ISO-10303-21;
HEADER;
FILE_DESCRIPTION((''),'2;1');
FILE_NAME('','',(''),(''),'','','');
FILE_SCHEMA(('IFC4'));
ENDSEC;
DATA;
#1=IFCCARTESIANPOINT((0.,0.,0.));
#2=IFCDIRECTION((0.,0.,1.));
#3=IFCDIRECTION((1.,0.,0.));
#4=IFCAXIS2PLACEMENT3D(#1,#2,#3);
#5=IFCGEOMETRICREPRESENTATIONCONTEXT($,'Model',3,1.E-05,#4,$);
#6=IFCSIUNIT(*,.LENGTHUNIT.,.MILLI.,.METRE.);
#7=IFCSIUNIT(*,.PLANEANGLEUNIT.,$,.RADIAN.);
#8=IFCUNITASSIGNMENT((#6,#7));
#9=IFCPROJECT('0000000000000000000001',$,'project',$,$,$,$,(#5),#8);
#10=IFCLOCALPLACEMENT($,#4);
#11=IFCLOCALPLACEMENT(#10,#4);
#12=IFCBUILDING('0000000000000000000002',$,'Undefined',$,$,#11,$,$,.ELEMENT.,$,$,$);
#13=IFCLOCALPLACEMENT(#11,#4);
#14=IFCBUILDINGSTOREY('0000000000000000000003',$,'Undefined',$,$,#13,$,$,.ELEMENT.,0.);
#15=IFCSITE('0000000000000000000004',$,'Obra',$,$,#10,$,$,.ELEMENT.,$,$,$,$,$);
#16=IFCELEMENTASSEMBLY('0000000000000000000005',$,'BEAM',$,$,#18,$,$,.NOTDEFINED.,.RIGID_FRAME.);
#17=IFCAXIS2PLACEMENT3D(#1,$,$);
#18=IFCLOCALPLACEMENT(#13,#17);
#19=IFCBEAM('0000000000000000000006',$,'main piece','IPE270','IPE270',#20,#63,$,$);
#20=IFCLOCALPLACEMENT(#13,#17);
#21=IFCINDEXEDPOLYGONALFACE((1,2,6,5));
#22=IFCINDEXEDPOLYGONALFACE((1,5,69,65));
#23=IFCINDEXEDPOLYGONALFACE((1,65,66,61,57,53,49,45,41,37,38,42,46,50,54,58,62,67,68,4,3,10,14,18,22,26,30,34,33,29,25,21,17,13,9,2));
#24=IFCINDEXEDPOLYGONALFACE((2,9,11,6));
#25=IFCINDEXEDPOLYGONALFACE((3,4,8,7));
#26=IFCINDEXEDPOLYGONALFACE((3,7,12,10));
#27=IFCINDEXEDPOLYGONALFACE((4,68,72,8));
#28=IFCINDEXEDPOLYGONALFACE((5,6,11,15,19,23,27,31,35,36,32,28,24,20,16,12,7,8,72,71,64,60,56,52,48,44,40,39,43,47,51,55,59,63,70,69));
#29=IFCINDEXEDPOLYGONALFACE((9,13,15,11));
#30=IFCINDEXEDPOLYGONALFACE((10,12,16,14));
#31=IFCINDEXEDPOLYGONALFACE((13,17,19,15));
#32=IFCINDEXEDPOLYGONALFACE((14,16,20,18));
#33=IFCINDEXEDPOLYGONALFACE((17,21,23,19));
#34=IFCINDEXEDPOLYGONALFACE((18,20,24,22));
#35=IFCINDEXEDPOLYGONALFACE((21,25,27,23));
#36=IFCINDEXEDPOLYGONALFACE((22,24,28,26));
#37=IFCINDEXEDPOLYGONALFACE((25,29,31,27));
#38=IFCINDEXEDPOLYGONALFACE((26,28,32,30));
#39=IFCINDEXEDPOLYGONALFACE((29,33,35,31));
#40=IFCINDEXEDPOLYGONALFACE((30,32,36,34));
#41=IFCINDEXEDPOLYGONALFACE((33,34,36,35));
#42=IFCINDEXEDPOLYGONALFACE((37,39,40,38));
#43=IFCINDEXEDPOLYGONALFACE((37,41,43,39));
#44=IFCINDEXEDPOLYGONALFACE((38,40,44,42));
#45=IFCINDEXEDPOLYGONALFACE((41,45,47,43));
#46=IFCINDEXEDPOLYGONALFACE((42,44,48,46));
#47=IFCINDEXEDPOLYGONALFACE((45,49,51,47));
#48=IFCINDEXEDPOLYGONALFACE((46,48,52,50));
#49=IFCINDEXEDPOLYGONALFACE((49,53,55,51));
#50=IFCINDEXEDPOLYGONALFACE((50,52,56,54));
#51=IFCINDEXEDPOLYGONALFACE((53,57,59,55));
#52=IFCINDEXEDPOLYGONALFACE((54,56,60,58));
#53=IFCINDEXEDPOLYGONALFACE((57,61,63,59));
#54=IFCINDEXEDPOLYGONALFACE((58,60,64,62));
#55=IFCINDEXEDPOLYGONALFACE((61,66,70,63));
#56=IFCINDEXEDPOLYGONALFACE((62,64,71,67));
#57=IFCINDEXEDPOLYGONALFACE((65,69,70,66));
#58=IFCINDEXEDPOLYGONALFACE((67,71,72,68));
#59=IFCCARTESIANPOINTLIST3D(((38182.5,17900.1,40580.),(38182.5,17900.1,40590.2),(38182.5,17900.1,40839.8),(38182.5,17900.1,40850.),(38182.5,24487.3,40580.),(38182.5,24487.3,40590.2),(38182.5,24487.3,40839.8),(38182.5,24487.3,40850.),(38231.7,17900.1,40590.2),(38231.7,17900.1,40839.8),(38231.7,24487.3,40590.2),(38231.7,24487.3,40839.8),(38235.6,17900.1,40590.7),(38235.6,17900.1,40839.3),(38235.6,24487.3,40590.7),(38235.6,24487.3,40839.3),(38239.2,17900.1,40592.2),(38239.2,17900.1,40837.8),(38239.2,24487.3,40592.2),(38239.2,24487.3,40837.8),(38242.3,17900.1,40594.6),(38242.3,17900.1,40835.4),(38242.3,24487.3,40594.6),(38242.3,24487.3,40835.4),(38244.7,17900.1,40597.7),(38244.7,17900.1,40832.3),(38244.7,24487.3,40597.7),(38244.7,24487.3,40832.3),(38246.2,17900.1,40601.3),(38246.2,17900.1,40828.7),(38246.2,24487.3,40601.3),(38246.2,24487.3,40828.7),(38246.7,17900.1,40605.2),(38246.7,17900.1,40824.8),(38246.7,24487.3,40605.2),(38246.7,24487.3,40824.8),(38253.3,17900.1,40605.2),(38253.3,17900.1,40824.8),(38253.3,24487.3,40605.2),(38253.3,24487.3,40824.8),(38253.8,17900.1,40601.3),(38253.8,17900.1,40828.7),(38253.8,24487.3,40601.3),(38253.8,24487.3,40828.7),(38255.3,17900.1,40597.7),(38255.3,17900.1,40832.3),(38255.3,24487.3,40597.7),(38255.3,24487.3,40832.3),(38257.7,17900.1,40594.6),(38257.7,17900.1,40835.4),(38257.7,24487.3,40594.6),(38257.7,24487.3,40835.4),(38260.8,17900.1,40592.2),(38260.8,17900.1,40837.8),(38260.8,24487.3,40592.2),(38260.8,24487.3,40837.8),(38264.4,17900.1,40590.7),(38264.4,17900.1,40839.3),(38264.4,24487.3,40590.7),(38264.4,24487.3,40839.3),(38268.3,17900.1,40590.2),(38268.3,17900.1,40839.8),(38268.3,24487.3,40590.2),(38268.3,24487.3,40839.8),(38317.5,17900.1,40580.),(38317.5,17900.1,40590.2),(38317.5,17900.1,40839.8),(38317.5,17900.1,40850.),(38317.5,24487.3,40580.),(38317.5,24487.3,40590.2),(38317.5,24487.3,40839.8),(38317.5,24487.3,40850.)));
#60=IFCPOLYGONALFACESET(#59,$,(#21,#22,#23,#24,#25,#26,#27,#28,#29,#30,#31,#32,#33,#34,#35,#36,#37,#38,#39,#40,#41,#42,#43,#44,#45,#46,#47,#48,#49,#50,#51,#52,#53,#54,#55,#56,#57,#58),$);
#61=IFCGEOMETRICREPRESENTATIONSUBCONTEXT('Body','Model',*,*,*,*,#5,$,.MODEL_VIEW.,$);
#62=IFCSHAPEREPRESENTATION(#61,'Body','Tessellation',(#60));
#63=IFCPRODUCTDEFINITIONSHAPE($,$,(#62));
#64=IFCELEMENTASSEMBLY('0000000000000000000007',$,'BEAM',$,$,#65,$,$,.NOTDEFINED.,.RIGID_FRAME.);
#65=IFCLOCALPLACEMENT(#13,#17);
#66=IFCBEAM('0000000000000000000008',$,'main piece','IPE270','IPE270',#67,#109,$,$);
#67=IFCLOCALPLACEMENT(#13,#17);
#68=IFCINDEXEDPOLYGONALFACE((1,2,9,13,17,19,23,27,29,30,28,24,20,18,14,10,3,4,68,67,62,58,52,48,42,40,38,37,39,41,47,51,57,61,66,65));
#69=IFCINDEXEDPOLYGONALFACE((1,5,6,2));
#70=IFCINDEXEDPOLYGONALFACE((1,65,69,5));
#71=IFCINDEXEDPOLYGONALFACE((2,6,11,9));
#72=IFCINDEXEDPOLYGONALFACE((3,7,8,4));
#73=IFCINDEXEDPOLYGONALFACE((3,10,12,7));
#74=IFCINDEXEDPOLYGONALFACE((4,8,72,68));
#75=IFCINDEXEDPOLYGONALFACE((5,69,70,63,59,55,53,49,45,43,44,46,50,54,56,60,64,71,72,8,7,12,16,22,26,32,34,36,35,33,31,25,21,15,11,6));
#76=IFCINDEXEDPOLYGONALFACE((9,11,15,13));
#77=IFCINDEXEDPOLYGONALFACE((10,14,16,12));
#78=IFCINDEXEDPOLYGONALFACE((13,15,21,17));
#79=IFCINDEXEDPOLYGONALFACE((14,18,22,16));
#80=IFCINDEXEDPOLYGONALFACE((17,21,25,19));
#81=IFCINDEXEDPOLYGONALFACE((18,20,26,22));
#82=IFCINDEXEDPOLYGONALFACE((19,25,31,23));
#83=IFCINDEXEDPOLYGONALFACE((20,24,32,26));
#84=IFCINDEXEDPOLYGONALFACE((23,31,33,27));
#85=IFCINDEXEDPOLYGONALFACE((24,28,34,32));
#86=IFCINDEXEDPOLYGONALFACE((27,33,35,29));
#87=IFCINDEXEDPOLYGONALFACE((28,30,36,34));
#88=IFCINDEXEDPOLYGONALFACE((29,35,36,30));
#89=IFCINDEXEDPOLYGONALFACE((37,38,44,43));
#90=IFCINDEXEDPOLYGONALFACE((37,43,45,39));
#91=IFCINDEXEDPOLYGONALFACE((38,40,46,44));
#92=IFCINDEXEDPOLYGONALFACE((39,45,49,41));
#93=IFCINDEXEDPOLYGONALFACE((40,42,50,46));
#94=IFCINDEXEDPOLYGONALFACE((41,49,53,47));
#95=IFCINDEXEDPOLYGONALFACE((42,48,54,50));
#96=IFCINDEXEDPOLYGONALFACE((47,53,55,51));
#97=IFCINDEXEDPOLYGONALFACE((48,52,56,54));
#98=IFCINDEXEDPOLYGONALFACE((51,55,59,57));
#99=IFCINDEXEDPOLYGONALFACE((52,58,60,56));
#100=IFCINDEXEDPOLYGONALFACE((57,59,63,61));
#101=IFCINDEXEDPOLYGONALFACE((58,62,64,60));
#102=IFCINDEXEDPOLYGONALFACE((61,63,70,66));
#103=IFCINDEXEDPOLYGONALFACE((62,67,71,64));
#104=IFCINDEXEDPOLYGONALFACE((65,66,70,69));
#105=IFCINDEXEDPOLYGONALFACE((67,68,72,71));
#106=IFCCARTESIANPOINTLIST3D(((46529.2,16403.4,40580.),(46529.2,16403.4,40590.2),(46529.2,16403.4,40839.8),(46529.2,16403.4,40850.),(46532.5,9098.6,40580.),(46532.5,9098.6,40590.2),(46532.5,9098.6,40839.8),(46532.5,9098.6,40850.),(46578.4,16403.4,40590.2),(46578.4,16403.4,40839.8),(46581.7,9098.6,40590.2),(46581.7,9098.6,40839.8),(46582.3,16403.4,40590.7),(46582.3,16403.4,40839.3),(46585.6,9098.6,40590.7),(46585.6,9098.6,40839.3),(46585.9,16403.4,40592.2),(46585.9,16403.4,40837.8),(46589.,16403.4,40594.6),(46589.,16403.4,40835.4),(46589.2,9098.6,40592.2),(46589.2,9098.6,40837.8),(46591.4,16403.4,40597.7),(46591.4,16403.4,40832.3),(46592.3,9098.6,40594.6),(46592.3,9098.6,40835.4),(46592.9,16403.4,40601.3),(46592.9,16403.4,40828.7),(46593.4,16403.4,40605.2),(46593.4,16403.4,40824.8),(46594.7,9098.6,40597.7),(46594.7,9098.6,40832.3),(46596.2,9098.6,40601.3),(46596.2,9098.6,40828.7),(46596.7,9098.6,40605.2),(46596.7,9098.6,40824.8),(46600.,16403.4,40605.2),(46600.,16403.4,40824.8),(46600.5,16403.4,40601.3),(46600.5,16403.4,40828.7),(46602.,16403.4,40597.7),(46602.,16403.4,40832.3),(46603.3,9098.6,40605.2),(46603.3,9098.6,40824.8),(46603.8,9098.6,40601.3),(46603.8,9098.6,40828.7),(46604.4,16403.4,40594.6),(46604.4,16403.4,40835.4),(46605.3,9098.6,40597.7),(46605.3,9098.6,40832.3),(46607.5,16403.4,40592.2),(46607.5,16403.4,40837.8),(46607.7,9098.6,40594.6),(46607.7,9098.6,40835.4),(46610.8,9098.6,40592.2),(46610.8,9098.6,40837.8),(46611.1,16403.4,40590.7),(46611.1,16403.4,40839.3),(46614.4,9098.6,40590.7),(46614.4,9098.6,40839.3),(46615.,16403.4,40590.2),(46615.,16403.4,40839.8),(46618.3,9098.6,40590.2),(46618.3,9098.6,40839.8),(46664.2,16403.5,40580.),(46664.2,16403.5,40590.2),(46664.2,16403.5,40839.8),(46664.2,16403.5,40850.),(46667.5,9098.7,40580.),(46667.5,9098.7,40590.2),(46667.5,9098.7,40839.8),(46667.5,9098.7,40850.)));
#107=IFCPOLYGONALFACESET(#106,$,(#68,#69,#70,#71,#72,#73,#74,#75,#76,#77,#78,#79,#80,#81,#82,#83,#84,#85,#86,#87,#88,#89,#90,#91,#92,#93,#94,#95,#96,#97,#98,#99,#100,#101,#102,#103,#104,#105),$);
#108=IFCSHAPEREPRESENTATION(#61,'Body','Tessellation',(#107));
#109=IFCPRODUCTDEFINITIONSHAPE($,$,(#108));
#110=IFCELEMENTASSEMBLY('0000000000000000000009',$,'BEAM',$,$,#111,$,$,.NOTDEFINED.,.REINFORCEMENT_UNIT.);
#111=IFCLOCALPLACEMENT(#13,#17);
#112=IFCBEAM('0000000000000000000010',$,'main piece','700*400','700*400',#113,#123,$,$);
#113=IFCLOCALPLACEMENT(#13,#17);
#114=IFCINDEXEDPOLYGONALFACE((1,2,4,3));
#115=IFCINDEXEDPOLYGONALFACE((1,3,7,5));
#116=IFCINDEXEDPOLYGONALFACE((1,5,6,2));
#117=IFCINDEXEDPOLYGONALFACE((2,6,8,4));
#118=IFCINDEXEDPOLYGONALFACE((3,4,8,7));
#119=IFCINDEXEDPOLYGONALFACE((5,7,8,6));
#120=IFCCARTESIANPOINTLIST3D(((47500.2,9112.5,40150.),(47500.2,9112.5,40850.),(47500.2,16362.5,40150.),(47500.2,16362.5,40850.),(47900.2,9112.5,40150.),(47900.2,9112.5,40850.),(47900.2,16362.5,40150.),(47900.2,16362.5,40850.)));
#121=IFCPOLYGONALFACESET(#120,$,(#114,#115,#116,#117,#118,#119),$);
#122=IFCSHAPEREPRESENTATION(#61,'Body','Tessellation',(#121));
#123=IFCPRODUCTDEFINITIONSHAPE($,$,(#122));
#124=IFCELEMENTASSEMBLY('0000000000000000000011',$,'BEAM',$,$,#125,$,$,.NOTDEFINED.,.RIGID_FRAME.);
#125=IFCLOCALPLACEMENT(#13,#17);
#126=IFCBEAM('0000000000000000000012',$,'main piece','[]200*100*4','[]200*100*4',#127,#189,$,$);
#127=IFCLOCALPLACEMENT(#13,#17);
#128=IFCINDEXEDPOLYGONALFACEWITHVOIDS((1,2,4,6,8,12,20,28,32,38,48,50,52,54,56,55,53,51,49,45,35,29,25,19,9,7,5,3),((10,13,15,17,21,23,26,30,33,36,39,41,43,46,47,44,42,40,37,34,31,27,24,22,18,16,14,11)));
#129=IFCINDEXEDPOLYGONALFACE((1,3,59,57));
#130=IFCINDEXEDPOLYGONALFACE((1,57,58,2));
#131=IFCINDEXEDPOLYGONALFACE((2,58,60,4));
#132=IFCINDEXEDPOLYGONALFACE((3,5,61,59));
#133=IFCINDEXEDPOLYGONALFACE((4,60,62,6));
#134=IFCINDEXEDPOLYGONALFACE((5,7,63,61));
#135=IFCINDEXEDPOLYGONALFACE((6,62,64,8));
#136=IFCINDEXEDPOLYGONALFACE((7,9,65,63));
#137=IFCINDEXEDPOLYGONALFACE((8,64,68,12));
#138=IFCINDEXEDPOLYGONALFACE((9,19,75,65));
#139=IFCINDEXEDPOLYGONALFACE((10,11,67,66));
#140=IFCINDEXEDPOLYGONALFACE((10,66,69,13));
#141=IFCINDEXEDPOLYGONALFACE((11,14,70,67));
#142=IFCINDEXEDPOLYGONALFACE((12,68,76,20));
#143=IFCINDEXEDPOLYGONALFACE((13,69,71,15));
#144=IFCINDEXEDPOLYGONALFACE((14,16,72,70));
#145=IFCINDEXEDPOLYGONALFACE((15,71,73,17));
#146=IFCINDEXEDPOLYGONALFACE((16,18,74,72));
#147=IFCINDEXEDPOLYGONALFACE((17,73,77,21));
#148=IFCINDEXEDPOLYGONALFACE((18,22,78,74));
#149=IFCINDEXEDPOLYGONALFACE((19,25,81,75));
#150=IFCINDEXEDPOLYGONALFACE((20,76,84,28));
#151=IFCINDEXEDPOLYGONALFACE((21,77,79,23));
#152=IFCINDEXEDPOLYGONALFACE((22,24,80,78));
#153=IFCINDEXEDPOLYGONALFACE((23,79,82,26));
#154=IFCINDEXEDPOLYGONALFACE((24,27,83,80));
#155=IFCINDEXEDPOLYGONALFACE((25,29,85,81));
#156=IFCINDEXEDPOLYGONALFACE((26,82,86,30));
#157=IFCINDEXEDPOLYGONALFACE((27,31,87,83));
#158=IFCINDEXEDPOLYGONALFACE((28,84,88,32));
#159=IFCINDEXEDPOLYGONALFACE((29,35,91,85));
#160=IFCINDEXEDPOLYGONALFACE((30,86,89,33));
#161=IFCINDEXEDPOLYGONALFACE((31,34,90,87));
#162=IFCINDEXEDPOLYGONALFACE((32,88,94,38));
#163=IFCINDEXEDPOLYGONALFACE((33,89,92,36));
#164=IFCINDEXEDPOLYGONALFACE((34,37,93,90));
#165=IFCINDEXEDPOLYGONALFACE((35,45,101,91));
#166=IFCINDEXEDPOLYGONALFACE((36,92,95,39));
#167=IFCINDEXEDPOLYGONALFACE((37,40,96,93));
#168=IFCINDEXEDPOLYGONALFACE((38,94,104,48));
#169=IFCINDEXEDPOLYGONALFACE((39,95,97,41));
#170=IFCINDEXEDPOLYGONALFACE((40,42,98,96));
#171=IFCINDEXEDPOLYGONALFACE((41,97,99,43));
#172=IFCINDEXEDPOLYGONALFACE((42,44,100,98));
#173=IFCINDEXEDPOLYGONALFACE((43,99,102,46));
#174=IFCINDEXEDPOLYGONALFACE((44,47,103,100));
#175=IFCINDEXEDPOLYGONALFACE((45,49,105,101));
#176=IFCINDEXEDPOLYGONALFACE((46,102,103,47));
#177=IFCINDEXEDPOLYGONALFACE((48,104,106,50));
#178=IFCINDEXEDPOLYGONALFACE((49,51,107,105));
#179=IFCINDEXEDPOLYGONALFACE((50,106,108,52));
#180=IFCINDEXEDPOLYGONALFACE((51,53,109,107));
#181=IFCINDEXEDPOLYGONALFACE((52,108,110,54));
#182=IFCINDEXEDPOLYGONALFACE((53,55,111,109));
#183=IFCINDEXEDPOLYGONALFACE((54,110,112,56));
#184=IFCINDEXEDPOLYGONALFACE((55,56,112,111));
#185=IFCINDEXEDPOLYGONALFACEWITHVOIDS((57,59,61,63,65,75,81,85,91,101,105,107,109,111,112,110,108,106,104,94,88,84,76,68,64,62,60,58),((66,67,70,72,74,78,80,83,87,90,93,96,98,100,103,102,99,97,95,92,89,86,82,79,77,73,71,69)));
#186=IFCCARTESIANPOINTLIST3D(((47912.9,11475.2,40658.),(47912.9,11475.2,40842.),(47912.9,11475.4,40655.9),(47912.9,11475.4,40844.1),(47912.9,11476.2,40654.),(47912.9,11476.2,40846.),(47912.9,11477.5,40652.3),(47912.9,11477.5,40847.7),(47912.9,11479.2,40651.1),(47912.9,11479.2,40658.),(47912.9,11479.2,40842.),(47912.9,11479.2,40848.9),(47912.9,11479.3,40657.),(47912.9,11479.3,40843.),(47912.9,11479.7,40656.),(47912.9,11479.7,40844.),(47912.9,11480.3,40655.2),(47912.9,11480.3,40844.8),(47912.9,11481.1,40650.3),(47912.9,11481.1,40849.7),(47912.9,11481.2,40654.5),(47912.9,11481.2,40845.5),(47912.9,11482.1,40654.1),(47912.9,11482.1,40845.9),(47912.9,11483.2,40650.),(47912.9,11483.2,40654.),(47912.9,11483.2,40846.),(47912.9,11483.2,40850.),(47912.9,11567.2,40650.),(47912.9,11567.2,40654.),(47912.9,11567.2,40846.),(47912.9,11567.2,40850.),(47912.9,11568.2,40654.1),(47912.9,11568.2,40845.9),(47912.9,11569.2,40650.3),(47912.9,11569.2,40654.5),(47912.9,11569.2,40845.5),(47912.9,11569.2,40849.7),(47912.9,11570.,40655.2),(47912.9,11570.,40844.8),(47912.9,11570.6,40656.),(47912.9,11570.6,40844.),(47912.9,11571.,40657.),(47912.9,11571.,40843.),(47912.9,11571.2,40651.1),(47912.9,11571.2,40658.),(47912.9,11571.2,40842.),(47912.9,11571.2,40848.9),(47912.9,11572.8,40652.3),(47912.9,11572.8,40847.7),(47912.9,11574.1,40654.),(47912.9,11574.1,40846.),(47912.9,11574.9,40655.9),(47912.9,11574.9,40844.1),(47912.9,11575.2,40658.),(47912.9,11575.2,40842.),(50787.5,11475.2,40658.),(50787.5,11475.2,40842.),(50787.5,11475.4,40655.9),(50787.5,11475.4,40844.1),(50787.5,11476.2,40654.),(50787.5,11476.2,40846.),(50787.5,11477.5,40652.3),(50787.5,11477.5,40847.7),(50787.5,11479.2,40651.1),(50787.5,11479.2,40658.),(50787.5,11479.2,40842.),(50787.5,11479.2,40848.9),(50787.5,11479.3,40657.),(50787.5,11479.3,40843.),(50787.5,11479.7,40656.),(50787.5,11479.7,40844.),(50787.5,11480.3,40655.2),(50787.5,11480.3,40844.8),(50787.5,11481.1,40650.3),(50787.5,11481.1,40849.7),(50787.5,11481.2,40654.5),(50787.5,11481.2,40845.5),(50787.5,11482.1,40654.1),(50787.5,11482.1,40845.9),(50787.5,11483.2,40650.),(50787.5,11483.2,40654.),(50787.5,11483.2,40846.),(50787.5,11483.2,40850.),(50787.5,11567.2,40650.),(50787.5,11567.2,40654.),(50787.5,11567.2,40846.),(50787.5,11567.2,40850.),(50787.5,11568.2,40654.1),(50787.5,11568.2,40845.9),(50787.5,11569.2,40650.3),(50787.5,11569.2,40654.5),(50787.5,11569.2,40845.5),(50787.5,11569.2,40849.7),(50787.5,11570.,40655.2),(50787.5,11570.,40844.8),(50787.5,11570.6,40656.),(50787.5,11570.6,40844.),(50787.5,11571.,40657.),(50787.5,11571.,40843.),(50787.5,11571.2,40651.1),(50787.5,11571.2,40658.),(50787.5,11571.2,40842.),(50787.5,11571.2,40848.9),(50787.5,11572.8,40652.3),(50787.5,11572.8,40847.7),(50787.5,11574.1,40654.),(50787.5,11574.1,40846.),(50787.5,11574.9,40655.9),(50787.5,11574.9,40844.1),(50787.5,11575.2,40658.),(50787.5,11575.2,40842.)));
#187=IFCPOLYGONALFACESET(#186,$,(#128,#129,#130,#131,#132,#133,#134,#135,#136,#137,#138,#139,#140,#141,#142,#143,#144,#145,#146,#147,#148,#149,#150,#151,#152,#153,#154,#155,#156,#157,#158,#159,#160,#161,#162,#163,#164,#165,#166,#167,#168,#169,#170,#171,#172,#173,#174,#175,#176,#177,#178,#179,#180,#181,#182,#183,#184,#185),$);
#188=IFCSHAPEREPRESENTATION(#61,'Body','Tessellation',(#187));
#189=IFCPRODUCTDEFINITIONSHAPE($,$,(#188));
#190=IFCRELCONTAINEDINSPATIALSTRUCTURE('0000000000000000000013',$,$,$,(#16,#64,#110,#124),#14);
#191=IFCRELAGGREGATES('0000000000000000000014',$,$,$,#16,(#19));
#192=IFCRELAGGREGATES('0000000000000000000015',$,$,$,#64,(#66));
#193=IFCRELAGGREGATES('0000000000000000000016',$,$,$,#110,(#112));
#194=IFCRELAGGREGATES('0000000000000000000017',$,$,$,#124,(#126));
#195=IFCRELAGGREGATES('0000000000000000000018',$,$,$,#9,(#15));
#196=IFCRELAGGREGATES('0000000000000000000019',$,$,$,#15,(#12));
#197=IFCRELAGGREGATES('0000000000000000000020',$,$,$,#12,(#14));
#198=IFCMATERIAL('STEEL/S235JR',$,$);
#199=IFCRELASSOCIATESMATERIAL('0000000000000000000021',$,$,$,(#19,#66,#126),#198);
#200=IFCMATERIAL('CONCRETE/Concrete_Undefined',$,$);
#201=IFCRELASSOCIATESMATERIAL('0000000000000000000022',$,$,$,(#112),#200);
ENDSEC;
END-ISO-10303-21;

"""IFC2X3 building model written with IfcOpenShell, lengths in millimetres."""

from ifc_helpers import new_model, si_unit, frame, origin_with_axes, origin_2d_with_axis, place, context, subcontext, project, spatial, rectangle, hollow_rectangle, i_section, extrude, material, element, aggregate, save


model = new_model("IFC2X3")

# Units and contexts
model_context = context("Model", 3, precision=1e-05, world=origin_with_axes())
body_context = subcontext(model_context, "Body", "Model", "MODEL_VIEW")
ifc_project = project(units=[si_unit("LENGTHUNIT", "METRE", prefix="MILLI"), si_unit("PLANEANGLEUNIT", "RADIAN")], contexts=[model_context])

# Site, building, storey
site_placement = place(None, origin_with_axes())
site = spatial("IfcSite", under=ifc_project, at=site_placement, Name="Obra", CompositionType="ELEMENT")
building_placement = place(site_placement, origin_with_axes())
building = spatial("IfcBuilding", under=site, at=building_placement, Name="Undefined", CompositionType="ELEMENT")
storey_placement = place(building_placement, origin_with_axes())
storey = spatial("IfcBuildingStorey", under=building, at=storey_placement, Name="Undefined", CompositionType="ELEMENT", Elevation=0.0)

# Element assemblies, beams
ifc_material_1 = material(Name="CONCRETE/Concrete_Undefined")
ifc_material_2 = material(Name="STEEL/S235JR")
assembly_1_placement = place(storey_placement, origin_with_axes())
assembly_1 = element("IfcElementAssembly", 1, at=assembly_1_placement, inside=storey, Name="BEAM", AssemblyPlace="NOTDEFINED", PredefinedType="RIGID_FRAME")
beam_1_placement = place(assembly_1_placement, frame((38250.0, 17900.1, 40715.0), z_axis=(0.0, 0.0, 1.0), x_axis=(0.0, 1.0, 0.0)))
beam_1 = element("IfcBeam", 2, at=beam_1_placement, material=ifc_material_2, Name="main piece", Description="IPE270", ObjectType="IPE270", context=body_context, shape_type="SweptSolid", body=[
    extrude(i_section(OverallWidth=135.0, OverallDepth=270.0, WebThickness=6.6, FlangeThickness=10.2, FilletRadius=15.0, at=origin_2d_with_axis()), frame((6587.2, 0.0, 0.0), z_axis=(-1.0, 0.0, 0.0), x_axis=(0.0, -1.0, 0.0)), (0.0, 0.0, 1.0), 6587.2),
])
aggregate(assembly_1, [beam_1])
assembly_2_placement = place(storey_placement, origin_with_axes())
assembly_2 = element("IfcElementAssembly", 3, at=assembly_2_placement, inside=storey, Name="BEAM", AssemblyPlace="NOTDEFINED", PredefinedType="RIGID_FRAME")
beam_2_placement = place(assembly_2_placement, frame((46596.7, 16403.4, 40715.0), z_axis=(0.0, 0.0, 1.0), x_axis=(0.000452, -1.0, 0.0)))
beam_2 = element("IfcBeam", 4, at=beam_2_placement, material=ifc_material_2, Name="main piece", Description="IPE270", ObjectType="IPE270", context=body_context, shape_type="SweptSolid", body=[
    extrude(i_section(OverallWidth=135.0, OverallDepth=270.0, WebThickness=6.6, FlangeThickness=10.2, FilletRadius=15.0, at=origin_2d_with_axis()), frame((7304.8, 0.0, 0.0), z_axis=(-1.0, 0.0, 0.0), x_axis=(0.0, -1.0, 0.0)), (0.0, 0.0, 1.0), 7304.8),
])
aggregate(assembly_2, [beam_2])
assembly_3_placement = place(storey_placement, origin_with_axes())
assembly_3 = element("IfcElementAssembly", 5, at=assembly_3_placement, inside=storey, Name="BEAM", AssemblyPlace="NOTDEFINED", PredefinedType="REINFORCEMENT_UNIT")
beam_3_placement = place(assembly_3_placement, frame((47700.2, 9112.5, 40500.0), z_axis=(0.0, 0.0, 1.0), x_axis=(-0.000002, 1.0, 0.0)))
beam_3 = element("IfcBeam", 6, at=beam_3_placement, material=ifc_material_1, Name="main piece", Description="700*400", ObjectType="700*400", context=body_context, shape_type="SweptSolid", body=[
    extrude(rectangle(XDim=400.0, YDim=700.0, at=origin_2d_with_axis()), frame((7250.0, 0.0, 0.0), z_axis=(-1.0, 0.0, 0.0), x_axis=(0.0, -1.0, 0.0)), (0.0, 0.0, 1.0), 7250.0),
])
aggregate(assembly_3, [beam_3])
assembly_4_placement = place(storey_placement, origin_with_axes())
assembly_4 = element("IfcElementAssembly", 7, at=assembly_4_placement, inside=storey, Name="BEAM", AssemblyPlace="NOTDEFINED", PredefinedType="RIGID_FRAME")
beam_4_placement = place(assembly_4_placement, frame((47912.9, 11525.2, 40750.0), z_axis=(0.0, 0.0, 1.0), x_axis=(1.0, 0.0, 0.0)))
beam_4 = element("IfcBeam", 8, at=beam_4_placement, material=ifc_material_2, Name="main piece", Description="[]200*100*4", ObjectType="[]200*100*4", context=body_context, shape_type="SweptSolid", body=[
    extrude(hollow_rectangle(XDim=100.0, YDim=200.0, WallThickness=4.0, InnerFilletRadius=4.0, OuterFilletRadius=8.0, at=origin_2d_with_axis()), frame((2874.6, 0.0, 0.0), z_axis=(-1.0, 0.0, 0.0), x_axis=(0.0, -1.0, 0.0)), (0.0, 0.0, 1.0), 2874.6),
])
aggregate(assembly_4, [beam_4])

save(model, "model.ifc")
